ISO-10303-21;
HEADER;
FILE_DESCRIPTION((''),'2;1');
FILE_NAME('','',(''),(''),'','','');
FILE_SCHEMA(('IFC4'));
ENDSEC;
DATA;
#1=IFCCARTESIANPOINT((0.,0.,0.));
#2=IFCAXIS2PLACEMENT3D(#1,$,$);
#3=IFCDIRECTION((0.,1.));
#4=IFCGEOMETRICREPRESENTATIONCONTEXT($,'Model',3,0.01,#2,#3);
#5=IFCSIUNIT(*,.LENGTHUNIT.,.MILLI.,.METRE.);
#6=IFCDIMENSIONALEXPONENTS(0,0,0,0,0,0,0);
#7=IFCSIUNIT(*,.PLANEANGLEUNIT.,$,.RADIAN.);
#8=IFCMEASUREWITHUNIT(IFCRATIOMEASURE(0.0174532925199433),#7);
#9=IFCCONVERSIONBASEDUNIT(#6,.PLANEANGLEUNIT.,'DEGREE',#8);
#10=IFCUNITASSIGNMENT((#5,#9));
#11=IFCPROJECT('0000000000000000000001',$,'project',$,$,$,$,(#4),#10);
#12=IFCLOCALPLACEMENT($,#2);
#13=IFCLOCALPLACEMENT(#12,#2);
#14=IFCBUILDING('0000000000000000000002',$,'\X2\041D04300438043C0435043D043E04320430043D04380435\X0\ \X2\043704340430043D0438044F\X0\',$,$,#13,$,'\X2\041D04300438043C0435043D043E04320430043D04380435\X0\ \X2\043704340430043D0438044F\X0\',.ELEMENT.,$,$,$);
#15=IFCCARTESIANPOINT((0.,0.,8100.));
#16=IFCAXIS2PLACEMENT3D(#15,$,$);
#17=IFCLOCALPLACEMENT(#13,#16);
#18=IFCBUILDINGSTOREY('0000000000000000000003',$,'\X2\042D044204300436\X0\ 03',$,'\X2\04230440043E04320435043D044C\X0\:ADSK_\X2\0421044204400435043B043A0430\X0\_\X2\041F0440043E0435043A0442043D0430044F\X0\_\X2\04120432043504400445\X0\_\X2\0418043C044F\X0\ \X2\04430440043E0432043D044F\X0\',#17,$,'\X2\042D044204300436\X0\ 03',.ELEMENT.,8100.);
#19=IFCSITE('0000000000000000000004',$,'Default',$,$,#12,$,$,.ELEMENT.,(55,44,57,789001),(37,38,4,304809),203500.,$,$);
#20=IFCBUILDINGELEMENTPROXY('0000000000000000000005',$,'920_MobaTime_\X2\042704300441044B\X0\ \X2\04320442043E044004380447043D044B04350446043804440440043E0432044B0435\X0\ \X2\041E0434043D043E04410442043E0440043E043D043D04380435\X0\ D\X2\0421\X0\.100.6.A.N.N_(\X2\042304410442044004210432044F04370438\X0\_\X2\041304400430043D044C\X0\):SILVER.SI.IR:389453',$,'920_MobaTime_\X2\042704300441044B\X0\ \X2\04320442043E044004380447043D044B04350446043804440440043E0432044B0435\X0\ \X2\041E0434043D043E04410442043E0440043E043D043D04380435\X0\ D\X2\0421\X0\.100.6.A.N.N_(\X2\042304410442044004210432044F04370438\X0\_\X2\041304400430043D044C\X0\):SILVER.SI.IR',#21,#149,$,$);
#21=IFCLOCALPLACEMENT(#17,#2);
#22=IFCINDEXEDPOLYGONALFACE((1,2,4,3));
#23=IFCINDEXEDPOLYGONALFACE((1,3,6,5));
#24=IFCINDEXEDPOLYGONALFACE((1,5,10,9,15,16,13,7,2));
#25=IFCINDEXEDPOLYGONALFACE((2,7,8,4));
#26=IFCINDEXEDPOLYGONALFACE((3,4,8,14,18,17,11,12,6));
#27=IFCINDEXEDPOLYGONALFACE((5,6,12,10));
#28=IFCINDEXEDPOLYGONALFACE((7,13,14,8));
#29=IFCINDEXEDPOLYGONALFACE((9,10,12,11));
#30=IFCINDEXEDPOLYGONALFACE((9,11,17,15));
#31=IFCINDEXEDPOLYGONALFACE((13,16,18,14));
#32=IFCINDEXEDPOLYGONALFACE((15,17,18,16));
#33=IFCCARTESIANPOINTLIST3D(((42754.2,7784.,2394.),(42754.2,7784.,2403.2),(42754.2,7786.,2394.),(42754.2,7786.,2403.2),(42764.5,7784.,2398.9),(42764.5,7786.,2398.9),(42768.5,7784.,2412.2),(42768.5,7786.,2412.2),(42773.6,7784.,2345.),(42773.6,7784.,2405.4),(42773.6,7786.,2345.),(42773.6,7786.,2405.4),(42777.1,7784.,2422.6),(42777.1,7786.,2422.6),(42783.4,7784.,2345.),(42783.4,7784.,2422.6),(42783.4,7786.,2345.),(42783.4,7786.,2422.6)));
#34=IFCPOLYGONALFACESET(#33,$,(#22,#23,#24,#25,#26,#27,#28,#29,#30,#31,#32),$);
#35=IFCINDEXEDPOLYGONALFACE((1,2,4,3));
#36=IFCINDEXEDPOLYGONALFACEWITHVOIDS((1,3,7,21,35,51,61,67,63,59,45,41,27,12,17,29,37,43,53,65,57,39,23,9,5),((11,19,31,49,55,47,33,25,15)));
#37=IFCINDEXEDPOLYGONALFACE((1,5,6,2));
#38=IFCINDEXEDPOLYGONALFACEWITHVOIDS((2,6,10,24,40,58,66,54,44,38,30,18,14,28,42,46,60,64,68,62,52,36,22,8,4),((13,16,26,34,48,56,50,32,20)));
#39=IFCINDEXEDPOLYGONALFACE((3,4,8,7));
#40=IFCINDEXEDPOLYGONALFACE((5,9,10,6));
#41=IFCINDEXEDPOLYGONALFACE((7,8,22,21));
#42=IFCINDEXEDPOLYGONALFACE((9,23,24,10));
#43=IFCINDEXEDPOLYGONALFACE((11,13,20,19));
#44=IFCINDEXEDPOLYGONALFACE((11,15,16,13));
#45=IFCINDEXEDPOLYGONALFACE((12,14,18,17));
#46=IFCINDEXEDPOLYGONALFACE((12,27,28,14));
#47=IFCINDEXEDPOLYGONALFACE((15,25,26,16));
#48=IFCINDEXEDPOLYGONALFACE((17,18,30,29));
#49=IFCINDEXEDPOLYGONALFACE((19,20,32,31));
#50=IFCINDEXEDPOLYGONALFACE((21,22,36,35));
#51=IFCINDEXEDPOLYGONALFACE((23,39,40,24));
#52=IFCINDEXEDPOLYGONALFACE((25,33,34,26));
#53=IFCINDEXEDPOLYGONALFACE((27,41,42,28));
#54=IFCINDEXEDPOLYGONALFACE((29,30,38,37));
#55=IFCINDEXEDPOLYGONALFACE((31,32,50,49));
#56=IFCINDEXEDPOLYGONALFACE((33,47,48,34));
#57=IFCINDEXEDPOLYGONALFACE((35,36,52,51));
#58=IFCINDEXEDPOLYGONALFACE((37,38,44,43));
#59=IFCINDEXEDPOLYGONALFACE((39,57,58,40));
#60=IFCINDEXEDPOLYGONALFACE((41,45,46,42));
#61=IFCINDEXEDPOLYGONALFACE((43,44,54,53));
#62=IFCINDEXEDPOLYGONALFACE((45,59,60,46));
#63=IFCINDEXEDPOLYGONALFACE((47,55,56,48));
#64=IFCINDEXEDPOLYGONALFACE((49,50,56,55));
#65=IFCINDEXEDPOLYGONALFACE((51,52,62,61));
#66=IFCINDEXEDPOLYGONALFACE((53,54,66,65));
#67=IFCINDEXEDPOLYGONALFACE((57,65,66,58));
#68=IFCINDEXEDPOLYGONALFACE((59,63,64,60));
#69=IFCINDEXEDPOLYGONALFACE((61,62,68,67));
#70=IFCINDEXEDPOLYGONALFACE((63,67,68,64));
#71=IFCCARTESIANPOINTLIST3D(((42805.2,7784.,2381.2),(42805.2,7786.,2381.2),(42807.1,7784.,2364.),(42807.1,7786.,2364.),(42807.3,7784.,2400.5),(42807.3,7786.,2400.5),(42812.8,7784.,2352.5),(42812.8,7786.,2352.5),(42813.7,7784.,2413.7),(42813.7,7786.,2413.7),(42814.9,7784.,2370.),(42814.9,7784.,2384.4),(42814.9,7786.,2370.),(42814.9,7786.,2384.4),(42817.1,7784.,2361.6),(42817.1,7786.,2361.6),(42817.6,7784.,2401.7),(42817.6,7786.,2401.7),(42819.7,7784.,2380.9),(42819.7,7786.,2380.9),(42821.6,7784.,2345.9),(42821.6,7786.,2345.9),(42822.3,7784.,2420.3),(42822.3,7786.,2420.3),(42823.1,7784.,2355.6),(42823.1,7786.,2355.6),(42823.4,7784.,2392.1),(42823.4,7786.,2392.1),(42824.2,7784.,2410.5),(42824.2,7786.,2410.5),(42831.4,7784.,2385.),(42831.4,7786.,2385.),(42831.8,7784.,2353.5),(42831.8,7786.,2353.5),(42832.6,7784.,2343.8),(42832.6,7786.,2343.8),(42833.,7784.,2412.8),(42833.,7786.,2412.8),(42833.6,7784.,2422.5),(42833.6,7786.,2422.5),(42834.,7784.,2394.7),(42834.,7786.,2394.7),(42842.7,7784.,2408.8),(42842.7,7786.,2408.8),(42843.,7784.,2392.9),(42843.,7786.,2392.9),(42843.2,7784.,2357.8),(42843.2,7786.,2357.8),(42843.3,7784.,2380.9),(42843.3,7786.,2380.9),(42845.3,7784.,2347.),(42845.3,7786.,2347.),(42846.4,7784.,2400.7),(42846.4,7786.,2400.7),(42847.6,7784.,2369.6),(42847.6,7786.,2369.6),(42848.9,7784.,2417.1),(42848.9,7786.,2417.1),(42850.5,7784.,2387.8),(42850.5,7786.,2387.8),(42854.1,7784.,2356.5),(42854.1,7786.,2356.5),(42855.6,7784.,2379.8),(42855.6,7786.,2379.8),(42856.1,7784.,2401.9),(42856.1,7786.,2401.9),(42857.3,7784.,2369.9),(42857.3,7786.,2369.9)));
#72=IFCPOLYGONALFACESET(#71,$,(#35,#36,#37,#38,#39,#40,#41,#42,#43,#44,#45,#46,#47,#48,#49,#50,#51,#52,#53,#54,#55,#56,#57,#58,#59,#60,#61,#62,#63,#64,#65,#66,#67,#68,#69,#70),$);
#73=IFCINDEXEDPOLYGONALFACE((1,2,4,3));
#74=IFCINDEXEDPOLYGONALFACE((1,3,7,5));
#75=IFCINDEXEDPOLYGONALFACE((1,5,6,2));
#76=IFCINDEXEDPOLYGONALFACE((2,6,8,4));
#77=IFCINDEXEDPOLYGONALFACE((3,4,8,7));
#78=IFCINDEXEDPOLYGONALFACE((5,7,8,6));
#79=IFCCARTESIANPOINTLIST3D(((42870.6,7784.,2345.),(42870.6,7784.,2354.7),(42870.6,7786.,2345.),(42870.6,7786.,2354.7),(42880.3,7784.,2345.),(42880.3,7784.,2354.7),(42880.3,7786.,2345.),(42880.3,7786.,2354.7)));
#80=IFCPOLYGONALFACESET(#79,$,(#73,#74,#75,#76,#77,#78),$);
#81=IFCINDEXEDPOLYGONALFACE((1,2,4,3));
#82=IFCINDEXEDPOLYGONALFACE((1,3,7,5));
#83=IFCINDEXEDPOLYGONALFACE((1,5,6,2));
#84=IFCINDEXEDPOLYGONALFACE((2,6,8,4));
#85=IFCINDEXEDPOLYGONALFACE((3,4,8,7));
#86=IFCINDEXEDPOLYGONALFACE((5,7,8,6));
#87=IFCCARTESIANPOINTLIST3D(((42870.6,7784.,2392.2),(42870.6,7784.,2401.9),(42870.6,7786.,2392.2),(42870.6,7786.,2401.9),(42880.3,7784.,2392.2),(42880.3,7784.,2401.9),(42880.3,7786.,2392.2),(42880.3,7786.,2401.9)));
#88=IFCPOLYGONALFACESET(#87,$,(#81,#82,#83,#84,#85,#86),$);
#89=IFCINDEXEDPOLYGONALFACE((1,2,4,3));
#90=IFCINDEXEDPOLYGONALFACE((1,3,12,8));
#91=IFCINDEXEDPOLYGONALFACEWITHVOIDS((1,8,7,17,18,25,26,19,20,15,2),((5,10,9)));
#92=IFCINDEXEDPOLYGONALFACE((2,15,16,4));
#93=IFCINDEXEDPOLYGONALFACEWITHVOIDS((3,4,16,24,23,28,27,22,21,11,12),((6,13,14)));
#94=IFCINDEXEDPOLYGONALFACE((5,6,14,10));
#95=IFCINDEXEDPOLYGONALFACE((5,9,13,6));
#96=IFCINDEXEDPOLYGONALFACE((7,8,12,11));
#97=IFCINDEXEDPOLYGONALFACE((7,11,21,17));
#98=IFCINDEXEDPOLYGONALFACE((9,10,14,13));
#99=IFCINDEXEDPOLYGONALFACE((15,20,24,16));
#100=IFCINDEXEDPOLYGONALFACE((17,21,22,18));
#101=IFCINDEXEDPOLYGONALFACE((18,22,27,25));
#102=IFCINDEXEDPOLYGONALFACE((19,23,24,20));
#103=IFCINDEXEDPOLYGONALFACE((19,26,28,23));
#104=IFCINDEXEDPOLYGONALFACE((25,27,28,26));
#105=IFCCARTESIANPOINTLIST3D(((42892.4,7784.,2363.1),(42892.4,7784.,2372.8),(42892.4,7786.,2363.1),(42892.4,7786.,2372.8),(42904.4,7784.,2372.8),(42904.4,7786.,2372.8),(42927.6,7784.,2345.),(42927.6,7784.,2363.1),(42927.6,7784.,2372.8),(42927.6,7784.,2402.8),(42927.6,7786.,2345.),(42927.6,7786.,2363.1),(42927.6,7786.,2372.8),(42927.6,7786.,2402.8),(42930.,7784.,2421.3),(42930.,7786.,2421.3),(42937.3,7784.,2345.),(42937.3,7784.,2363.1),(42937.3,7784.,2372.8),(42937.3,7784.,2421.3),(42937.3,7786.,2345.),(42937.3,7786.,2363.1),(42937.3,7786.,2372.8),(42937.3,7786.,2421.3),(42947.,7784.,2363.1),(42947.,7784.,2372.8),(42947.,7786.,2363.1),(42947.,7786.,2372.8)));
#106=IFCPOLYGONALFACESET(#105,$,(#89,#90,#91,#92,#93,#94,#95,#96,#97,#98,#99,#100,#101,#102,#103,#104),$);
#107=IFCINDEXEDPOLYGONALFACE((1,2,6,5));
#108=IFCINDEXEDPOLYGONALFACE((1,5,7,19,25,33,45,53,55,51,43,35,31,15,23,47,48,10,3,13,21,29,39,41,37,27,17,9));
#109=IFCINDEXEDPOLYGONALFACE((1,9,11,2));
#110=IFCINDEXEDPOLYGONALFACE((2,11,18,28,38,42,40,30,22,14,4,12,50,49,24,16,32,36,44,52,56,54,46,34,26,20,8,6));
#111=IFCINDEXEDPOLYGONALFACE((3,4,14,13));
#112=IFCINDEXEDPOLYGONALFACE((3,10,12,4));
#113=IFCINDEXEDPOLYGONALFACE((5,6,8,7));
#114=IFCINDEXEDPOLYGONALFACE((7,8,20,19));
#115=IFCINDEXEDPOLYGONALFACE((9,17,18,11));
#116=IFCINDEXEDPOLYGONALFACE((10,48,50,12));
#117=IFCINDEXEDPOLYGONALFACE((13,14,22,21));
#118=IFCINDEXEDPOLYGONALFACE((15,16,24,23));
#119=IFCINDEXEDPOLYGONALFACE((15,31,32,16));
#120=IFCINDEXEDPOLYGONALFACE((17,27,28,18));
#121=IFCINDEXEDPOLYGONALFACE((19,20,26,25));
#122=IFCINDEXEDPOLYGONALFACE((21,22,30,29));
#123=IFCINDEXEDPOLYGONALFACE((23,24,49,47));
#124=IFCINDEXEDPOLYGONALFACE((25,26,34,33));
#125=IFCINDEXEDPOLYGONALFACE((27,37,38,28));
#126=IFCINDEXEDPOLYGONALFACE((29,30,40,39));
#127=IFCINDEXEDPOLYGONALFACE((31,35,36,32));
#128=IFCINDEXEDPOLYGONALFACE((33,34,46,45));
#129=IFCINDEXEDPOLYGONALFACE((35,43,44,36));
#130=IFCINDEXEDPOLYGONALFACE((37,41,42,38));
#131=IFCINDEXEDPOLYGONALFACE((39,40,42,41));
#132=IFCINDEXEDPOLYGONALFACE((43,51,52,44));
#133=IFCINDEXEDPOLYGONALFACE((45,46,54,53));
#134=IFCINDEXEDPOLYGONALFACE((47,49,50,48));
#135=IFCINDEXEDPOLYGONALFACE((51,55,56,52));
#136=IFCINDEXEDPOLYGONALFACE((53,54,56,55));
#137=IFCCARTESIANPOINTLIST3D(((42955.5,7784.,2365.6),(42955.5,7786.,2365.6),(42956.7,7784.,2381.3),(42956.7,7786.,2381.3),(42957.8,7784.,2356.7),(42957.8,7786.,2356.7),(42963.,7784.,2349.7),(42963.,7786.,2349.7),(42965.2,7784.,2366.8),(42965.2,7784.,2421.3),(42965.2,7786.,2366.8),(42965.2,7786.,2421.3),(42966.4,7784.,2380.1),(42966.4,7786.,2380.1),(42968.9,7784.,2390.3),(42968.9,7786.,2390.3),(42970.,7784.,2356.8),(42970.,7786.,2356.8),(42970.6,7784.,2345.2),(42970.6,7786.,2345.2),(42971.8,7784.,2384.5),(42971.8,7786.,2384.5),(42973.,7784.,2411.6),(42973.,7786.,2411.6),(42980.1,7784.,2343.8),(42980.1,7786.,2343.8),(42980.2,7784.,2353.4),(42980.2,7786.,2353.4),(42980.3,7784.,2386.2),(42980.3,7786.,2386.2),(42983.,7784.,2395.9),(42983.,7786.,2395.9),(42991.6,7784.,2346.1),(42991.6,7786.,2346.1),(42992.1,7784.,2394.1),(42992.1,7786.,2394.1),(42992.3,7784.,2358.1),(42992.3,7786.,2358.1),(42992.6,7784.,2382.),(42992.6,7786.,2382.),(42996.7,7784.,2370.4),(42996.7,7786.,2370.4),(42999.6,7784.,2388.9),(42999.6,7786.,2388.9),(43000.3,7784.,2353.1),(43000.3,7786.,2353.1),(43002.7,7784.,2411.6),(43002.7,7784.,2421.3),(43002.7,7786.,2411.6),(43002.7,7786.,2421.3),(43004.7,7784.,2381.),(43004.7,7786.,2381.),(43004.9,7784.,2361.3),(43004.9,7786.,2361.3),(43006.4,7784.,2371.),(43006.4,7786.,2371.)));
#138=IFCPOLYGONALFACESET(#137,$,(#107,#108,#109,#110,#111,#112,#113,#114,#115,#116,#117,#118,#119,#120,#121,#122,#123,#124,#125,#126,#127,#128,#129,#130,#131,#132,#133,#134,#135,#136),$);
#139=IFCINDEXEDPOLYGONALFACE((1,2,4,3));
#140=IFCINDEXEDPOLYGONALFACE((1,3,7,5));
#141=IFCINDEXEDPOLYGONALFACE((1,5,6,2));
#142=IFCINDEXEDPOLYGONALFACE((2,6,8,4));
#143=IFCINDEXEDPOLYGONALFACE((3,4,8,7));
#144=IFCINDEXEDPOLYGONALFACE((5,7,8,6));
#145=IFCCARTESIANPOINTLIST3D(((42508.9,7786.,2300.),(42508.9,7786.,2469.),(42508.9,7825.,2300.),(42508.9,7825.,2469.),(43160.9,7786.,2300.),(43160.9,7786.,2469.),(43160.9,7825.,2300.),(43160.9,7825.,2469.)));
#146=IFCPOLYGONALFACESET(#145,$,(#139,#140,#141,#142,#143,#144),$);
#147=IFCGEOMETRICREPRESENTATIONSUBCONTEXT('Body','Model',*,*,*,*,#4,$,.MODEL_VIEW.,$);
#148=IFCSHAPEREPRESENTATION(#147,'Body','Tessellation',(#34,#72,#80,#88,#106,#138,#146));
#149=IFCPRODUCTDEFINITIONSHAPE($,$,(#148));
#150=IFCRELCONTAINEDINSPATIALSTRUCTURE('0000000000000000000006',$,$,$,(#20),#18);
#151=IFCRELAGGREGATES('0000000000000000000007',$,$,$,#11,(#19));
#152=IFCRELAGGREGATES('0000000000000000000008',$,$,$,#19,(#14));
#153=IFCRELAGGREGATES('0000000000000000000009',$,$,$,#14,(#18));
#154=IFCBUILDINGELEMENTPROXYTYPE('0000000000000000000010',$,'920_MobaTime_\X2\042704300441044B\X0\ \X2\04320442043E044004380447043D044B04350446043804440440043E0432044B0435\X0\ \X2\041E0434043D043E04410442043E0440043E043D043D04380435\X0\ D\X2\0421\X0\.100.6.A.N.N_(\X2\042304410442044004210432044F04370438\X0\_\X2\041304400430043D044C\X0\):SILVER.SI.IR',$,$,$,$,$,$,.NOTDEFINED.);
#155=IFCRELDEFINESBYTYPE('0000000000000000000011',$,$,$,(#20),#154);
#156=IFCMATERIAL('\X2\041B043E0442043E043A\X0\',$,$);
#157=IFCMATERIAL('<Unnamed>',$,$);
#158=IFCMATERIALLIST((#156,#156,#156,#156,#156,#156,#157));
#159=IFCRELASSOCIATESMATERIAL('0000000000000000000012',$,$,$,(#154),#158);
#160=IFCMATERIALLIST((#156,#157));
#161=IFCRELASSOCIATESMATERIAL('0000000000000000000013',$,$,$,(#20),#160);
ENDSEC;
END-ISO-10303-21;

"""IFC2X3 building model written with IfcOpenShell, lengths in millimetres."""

from ifc_helpers import new_model, entity, si_unit, converted_unit, direction, frame, origin, origin_2d_with_axis, place, context, subcontext, project, spatial, polyline, rectangle, outline, extrude, source, transform, mapped, material, material_list, type_object, type_shapes, element, save


model = new_model("IFC2X3")

# Units and contexts
model_context = context("Model", 3, precision=0.01, world=origin(), true_north=direction((0.0, 1.0)))
body_context = subcontext(model_context, "Body", "Model", "MODEL_VIEW")
ifc_project = project(units=[si_unit("LENGTHUNIT", "METRE", prefix="MILLI"), converted_unit("PLANEANGLEUNIT", "DEGREE", entity("IfcRatioMeasure", 0.0174532925199433), si_unit("PLANEANGLEUNIT", "RADIAN"), dimensions=[0, 0, 0, 0, 0, 0, 0])], contexts=[model_context])

# Site, building, storey
site_placement = place(None, origin())
site = spatial("IfcSite", under=ifc_project, at=site_placement, Name="Default", CompositionType="ELEMENT", RefLatitude=(55, 44, 57, 789001), RefLongitude=(37, 38, 4, 304809), RefElevation=203500.0)
building_placement = place(site_placement, origin())
building = spatial("IfcBuilding", under=site, at=building_placement, Name="Наименование здания", LongName="Наименование здания", CompositionType="ELEMENT")
storey_placement = place(building_placement, frame((0.0, 0.0, 8100.0)))
storey = spatial("IfcBuildingStorey", under=building, at=storey_placement, Name="Этаж 03", ObjectType="Уровень:ADSK_Стрелка_Проектная_Вверх_Имя уровня", LongName="Этаж 03", CompositionType="ELEMENT", Elevation=8100.0)

# Building element proxy
ifc_material_1 = material(Name="Лоток")
ifc_material_2 = material(Name="<Unnamed>")
ifc_material_list_1 = material_list([ifc_material_1, ifc_material_1, ifc_material_1, ifc_material_1, ifc_material_1, ifc_material_1, ifc_material_2])
building_element_proxy_type = type_object("IfcBuildingElementProxyType", Name="920_MobaTime_Часы вторичныецифровые Односторонние DС.100.6.A.N.N_(УстрСвязи_Грань):SILVER.SI.IR", PredefinedType="NOTDEFINED", material=ifc_material_list_1)
shared_shape = source(origin(), body_context, "Body", "SweptSolid", [
    extrude(outline(polyline([(-49.3, -13.1), (28.2, -13.1), (28.2, -6.8), (17.9, 1.8), (8.8, 16.0), (-0.3, 16.0), (4.6, 5.8), (11.1, -3.4), (-49.3, -3.4), (-49.3, -13.1)])), frame((-64.6, 9.8, 39.0), z_axis=(0.0, 0.0, 1.0), x_axis=(0.0, 1.0, 0.0)), (0.0, 0.0, 1.0), 2.0),
    extrude(outline(polyline([(2.2, -27.6), (19.0, -27.6), (30.5, -16.1), (33.3, -4.9), (31.0, 5.8), (21.8, 17.2), (5.2, 27.3), (-11.1, 33.0), (-24.0, 32.7), (-33.6, 27.6), (-40.3, 18.6), (-42.8, 5.7), (-38.0, -6.3), (-27.2, -14.9), (-17.5, -17.7), (-8.2, -16.4), (-0.3, -11.9), (5.1, -4.5), (7.3, 6.2), (4.0, 17.2), (18.4, 7.3), (23.6, -2.4), (22.0, -11.4), (14.2, -18.4), (5.3, -18.3), (2.2, -27.6)]), holes=[polyline([(-9.0, 23.3), (-1.3, 14.3), (-2.5, 2.0), (-11.4, -7.0), (-23.4, -6.0), (-32.2, 2.9), (-31.2, 15.1), (-25.6, 22.1), (-17.5, 24.9), (-9.0, 23.3)])]), frame((-2.7, 3.6, 39.0), z_axis=(0.0, 0.0, 1.0), x_axis=(-0.427649, 0.903945, 0.0)), (0.0, 0.0, 1.0), 2.0),
    extrude(rectangle(XDim=9.7, YDim=9.7, at=origin_2d_with_axis()), frame((40.6, -34.7, 39.0)), (0.0, 0.0, 1.0), 2.0),
    extrude(rectangle(XDim=9.7, YDim=9.7, at=origin_2d_with_axis()), frame((40.6, 12.6, 39.0)), (0.0, 0.0, 1.0), 2.0),
    extrude(outline(polyline([(-0.9, -28.1), (8.8, -28.1), (8.8, -9.9), (18.5, -9.9), (18.5, -0.2), (8.8, -0.2), (8.8, 48.3), (1.5, 48.3), (-36.0, -0.2), (-36.0, -9.9), (-0.9, -9.9), (-0.9, -28.1)]), holes=[polyline([(-0.9, -0.2), (-24.1, -0.2), (-0.9, 29.7), (-0.9, -0.2)])]), frame((93.6, -11.4, 39.0)), (0.0, 0.0, 1.0), 2.0),
    extrude(outline(polyline([(3.3, -28.3), (12.5, -28.3), (20.5, -25.0), (26.8, -18.9), (30.7, -10.0), (31.4, 1.6), (26.9, 11.8), (20.1, 18.4), (11.1, 22.3), (1.0, 23.3), (-7.9, 20.4), (-14.9, 14.5), (-18.9, 6.2), (-17.1, -9.0), (-36.7, 0.5), (-29.1, 29.2), (-38.5, 31.7), (-48.1, -4.6), (-11.6, -23.1), (-8.0, -14.0), (-10.8, -7.6), (-10.2, 1.1), (-3.0, 11.8), (9.2, 12.8), (20.0, 5.5), (21.4, -7.5), (15.5, -16.4), (4.6, -18.6), (3.3, -28.3)])), frame((147.1, -8.5, 39.0), z_axis=(0.0, 0.0, 1.0), x_axis=(0.256974, -0.966418, 0.0)), (0.0, 0.0, 1.0), 2.0),
    extrude(rectangle(XDim=652.0, YDim=169.0, at=origin_2d_with_axis()), frame((0.0, 0.0, 0.0), z_axis=(0.0, 0.0, 1.0), x_axis=(-1.0, 0.0, 0.0)), (0.0, 0.0, 1.0), 39.0),
])
type_shapes(building_element_proxy_type, [shared_shape])
ifc_material_list_2 = material_list([ifc_material_1, ifc_material_2])
for number, where, z_axis, x_axis, name in (
    (1, (42834.9, 7825.0, 2384.5), (0.0, -1.0, 0.0), (1.0, 0.0, 0.0), "920_MobaTime_Часы вторичныецифровые Односторонние DС.100.6.A.N.N_(УстрСвязи_Грань):SILVER.SI.IR:389453"),
):
    element("IfcBuildingElementProxy", number, at=place(storey_placement, frame(where, z_axis=z_axis, x_axis=x_axis)), inside=storey, type_object=building_element_proxy_type, material=ifc_material_list_2, Name=name, ObjectType="920_MobaTime_Часы вторичныецифровые Односторонние DС.100.6.A.N.N_(УстрСвязи_Грань):SILVER.SI.IR", context=body_context, shape_type="MappedRepresentation", body=[
        mapped(shared_shape, transform((0.0, 0.0, 0.0), scale=1.0)),
    ])

save(model, "model.ifc")
